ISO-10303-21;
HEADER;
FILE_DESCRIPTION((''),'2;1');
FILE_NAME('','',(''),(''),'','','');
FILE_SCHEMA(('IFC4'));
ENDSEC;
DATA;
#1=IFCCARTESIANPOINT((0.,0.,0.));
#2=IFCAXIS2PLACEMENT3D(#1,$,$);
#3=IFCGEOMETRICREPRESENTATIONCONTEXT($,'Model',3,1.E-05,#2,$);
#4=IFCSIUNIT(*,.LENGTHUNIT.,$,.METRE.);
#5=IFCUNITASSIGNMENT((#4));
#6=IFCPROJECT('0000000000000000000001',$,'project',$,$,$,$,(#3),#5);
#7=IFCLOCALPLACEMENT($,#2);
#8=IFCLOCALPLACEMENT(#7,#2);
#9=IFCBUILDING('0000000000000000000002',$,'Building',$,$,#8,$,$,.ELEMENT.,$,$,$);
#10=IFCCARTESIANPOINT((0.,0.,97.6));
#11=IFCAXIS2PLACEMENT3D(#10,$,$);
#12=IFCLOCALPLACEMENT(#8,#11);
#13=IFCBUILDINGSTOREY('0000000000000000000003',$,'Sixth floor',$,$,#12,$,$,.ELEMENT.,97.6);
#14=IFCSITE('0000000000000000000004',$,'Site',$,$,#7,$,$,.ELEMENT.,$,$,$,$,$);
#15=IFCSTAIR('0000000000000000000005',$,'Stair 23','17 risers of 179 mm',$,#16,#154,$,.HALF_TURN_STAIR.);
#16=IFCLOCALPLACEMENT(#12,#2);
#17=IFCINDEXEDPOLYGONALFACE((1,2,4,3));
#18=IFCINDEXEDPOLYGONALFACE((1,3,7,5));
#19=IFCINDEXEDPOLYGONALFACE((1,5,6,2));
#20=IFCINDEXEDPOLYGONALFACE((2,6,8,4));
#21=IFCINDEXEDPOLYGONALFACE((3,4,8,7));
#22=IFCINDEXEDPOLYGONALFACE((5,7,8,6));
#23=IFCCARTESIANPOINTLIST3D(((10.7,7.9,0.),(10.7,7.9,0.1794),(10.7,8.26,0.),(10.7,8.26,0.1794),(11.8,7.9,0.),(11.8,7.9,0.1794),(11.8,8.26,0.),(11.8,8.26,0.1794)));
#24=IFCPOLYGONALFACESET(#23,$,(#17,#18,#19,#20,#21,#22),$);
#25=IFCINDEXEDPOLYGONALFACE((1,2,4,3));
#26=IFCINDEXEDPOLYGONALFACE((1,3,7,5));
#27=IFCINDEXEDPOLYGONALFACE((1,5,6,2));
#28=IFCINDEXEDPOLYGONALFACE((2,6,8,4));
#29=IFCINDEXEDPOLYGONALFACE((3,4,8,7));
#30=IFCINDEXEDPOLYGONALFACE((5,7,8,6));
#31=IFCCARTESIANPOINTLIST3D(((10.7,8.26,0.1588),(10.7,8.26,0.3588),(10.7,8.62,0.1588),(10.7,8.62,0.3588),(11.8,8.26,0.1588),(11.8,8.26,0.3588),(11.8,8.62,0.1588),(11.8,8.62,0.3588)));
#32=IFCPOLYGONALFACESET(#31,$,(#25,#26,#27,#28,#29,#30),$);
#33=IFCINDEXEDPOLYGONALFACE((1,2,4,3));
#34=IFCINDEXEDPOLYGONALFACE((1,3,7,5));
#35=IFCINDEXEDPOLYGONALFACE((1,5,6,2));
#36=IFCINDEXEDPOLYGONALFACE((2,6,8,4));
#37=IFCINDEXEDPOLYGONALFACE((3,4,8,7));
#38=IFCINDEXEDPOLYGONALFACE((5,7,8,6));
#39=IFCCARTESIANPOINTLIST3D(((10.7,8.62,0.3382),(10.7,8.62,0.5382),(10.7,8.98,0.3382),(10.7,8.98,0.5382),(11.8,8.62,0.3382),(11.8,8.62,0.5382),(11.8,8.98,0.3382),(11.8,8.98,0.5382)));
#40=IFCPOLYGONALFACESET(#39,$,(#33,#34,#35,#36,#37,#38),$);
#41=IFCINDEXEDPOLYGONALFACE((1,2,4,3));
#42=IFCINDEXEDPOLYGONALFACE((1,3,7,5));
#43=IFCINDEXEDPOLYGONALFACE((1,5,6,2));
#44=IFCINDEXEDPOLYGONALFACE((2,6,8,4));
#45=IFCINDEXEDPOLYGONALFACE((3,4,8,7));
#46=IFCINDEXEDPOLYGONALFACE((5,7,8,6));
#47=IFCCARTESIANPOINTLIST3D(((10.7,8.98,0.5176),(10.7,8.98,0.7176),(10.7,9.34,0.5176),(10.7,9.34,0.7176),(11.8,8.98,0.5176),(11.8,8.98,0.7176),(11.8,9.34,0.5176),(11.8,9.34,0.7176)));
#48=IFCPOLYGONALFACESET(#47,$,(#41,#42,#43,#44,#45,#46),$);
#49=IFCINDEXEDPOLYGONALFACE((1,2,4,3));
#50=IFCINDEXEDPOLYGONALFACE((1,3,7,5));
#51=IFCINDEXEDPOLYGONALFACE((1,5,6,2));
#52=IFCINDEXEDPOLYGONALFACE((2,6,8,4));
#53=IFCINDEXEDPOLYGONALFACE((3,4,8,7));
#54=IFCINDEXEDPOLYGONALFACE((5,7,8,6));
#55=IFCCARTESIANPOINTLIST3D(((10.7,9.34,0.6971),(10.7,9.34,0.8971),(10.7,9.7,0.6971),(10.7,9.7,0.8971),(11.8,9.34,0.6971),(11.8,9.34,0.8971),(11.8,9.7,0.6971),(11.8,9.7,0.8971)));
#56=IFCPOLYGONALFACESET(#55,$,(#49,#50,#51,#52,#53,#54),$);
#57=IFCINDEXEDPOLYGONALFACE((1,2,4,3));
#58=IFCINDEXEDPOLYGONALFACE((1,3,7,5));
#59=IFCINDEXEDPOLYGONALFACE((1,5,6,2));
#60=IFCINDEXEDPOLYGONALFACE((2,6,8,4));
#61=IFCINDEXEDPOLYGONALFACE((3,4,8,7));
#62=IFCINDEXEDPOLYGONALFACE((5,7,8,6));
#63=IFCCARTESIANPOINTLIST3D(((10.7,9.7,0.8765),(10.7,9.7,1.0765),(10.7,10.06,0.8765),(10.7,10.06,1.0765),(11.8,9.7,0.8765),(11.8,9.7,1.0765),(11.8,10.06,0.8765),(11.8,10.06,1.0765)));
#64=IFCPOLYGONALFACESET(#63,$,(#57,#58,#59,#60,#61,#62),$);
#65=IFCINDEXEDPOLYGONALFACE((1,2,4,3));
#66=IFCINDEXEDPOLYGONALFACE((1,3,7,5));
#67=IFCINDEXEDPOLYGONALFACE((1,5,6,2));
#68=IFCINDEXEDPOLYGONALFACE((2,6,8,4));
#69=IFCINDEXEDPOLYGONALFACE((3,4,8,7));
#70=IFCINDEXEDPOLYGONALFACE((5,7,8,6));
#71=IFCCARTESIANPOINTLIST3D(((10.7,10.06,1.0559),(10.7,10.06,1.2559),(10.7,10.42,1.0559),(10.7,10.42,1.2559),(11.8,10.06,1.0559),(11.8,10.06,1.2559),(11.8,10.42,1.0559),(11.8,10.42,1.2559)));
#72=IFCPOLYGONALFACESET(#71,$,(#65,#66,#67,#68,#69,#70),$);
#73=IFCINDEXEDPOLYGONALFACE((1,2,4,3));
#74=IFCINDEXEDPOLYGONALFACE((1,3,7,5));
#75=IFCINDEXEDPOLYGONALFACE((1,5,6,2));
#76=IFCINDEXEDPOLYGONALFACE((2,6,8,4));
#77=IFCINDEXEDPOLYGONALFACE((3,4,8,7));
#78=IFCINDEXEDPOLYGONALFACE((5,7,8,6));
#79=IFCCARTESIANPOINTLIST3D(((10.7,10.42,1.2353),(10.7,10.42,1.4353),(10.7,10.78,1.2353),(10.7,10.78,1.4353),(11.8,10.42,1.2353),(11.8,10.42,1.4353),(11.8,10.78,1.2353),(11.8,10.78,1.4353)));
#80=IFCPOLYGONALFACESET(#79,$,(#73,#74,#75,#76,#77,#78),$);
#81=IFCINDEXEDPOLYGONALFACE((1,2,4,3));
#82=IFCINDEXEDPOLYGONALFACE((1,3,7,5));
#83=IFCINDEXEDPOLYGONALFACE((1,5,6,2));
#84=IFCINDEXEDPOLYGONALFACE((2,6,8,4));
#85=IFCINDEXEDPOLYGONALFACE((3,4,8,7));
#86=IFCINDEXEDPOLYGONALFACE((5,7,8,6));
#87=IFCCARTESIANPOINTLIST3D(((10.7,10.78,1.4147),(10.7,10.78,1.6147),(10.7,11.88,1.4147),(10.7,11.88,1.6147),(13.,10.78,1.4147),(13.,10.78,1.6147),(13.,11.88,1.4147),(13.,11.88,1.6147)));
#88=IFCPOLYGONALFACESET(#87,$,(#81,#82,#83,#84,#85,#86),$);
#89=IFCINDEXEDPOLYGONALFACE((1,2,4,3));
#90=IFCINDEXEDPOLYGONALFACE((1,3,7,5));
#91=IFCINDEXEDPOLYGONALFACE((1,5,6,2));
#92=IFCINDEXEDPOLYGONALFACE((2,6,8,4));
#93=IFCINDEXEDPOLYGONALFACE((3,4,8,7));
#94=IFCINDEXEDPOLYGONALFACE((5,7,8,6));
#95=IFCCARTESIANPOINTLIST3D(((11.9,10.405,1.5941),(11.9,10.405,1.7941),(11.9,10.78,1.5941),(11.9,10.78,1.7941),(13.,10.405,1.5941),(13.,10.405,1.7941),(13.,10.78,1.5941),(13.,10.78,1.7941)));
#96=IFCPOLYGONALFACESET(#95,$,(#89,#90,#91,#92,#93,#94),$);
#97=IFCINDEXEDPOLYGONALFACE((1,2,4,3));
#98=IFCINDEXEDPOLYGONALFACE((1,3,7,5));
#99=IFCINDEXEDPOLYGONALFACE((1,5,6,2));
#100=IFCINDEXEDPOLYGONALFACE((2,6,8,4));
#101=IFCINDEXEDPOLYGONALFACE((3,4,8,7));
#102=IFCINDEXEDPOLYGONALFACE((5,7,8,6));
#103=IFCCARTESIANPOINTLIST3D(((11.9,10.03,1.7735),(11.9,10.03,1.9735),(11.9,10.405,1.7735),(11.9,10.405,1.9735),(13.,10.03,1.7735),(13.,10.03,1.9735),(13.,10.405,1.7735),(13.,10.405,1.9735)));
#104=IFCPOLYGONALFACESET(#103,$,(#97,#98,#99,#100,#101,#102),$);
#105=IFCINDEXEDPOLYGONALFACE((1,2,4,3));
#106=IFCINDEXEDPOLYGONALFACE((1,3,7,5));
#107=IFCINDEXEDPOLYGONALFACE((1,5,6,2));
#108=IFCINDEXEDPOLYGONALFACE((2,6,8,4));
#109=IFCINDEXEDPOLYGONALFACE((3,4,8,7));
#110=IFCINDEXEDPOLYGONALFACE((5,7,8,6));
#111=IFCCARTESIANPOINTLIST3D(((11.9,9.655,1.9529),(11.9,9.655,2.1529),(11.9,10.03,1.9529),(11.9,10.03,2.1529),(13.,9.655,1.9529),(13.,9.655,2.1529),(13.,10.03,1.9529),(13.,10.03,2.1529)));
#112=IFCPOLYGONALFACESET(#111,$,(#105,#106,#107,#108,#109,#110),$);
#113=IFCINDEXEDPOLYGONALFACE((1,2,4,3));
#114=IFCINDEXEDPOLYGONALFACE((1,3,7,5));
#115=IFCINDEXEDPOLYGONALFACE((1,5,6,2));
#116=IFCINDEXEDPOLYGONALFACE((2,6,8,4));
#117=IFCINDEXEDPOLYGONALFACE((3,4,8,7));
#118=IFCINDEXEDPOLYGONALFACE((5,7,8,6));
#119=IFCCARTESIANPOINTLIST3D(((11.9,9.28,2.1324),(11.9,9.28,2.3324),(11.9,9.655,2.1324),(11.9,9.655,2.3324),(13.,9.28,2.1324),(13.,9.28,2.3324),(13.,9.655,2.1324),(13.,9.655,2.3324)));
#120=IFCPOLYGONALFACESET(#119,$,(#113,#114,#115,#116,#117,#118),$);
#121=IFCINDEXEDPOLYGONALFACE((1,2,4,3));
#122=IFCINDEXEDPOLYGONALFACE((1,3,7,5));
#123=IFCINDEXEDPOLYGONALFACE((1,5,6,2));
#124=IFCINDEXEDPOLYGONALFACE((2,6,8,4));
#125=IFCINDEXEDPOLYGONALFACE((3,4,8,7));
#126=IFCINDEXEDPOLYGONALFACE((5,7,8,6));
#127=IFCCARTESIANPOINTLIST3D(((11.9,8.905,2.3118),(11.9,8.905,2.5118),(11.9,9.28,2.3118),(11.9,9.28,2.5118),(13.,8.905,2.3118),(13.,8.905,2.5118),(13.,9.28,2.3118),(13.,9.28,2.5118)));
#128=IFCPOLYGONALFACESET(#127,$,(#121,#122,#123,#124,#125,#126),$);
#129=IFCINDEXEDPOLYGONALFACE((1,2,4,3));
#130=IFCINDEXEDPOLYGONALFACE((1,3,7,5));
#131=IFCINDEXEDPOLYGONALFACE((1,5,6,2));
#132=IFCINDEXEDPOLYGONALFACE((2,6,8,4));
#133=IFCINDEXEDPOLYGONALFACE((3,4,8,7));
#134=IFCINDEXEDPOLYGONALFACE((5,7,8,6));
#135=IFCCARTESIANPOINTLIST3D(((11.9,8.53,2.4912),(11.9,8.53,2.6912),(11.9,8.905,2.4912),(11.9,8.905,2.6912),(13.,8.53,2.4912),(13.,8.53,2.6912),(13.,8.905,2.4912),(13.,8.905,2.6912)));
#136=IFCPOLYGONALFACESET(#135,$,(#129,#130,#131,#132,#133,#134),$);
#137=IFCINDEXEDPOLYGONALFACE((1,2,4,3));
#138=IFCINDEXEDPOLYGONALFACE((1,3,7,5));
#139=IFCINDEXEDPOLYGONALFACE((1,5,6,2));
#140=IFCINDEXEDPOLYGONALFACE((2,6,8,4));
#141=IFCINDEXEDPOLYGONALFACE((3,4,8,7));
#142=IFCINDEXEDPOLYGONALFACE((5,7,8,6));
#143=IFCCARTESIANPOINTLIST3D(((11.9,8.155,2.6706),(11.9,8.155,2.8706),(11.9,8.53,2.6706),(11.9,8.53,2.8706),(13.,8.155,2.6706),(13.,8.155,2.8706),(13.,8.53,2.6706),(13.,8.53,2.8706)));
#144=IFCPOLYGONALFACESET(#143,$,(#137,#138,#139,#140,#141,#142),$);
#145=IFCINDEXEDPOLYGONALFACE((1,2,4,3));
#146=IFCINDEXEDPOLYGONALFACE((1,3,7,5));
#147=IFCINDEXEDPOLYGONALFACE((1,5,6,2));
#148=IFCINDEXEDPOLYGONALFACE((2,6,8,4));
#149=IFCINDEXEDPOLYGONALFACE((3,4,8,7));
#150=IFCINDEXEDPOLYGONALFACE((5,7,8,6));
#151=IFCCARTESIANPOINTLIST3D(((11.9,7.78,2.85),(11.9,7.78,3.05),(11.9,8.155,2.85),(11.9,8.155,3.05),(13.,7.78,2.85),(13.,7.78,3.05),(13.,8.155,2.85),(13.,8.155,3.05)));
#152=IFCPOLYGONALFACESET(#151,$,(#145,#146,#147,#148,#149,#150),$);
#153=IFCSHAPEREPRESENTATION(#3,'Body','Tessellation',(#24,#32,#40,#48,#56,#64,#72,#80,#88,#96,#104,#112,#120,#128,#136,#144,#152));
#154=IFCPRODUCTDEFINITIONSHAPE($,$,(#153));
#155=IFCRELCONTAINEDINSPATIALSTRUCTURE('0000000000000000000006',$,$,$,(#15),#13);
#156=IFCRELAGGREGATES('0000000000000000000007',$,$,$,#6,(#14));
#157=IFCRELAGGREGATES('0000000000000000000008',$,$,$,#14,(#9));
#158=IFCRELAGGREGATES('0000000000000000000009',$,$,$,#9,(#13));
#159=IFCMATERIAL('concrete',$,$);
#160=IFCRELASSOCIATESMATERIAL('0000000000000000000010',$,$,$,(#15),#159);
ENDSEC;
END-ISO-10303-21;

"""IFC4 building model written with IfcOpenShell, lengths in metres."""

from ifc_helpers import new_model, si_unit, frame, origin, place, context, project, spatial, polyline, outline, extrude, material, element, save


model = new_model("IFC4")

# Units and contexts
model_context = context("Model", 3, precision=1e-05, world=origin())
ifc_project = project(units=[si_unit("LENGTHUNIT", "METRE")], contexts=[model_context])

# Site, building, storey
site_placement = place(None, origin())
site = spatial("IfcSite", under=ifc_project, at=site_placement, Name="Site", CompositionType="ELEMENT")
building_placement = place(site_placement, origin())
building = spatial("IfcBuilding", under=site, at=building_placement, Name="Building", CompositionType="ELEMENT")
storey_placement = place(building_placement, frame((0.0, 0.0, 97.6)))
storey = spatial("IfcBuildingStorey", under=building, at=storey_placement, Name="Sixth floor", CompositionType="ELEMENT", Elevation=97.6)

# Shared definitions
ifc_material = material(Name="concrete")

# Stair
stair_placement = place(storey_placement, frame((11.25, 7.9, 0.0), z_axis=(0.0, 0.0, 1.0), x_axis=(0.0, 1.0, 0.0)))
element("IfcStair", 1, at=stair_placement, inside=storey, material=ifc_material, Name="Stair 23", Description="17 risers of 179 mm", PredefinedType="HALF_TURN_STAIR", context=model_context, shape_type="SweptSolid", body=[
    extrude(outline(polyline([(0.0, -0.55), (0.36, -0.55), (0.36, 0.55), (0.0, 0.55), (0.0, -0.55)])), origin(), (0.0, 0.0, 1.0), 0.1794),
    extrude(outline(polyline([(0.36, -0.55), (0.72, -0.55), (0.72, 0.55), (0.36, 0.55), (0.36, -0.55)])), frame((0.0, 0.0, 0.1588)), (0.0, 0.0, 1.0), 0.2),
    extrude(outline(polyline([(0.72, -0.55), (1.08, -0.55), (1.08, 0.55), (0.72, 0.55), (0.72, -0.55)])), frame((0.0, 0.0, 0.3382)), (0.0, 0.0, 1.0), 0.2),
    extrude(outline(polyline([(1.08, -0.55), (1.44, -0.55), (1.44, 0.55), (1.08, 0.55), (1.08, -0.55)])), frame((0.0, 0.0, 0.5176)), (0.0, 0.0, 1.0), 0.2),
    extrude(outline(polyline([(1.44, -0.55), (1.8, -0.55), (1.8, 0.55), (1.44, 0.55), (1.44, -0.55)])), frame((0.0, 0.0, 0.6971)), (0.0, 0.0, 1.0), 0.2),
    extrude(outline(polyline([(1.8, -0.55), (2.16, -0.55), (2.16, 0.55), (1.8, 0.55), (1.8, -0.55)])), frame((0.0, 0.0, 0.8765)), (0.0, 0.0, 1.0), 0.2),
    extrude(outline(polyline([(2.16, -0.55), (2.52, -0.55), (2.52, 0.55), (2.16, 0.55), (2.16, -0.55)])), frame((0.0, 0.0, 1.0559)), (0.0, 0.0, 1.0), 0.2),
    extrude(outline(polyline([(2.52, -0.55), (2.88, -0.55), (2.88, 0.55), (2.52, 0.55), (2.52, -0.55)])), frame((0.0, 0.0, 1.2353)), (0.0, 0.0, 1.0), 0.2),
    extrude(outline(polyline([(2.88, -1.75), (3.98, -1.75), (3.98, 0.55), (2.88, 0.55), (2.88, -1.75)])), frame((0.0, 0.0, 1.4147)), (0.0, 0.0, 1.0), 0.2),
    extrude(outline(polyline([(2.505, -1.75), (2.88, -1.75), (2.88, -0.65), (2.505, -0.65), (2.505, -1.75)])), frame((0.0, 0.0, 1.5941)), (0.0, 0.0, 1.0), 0.2),
    extrude(outline(polyline([(2.13, -1.75), (2.505, -1.75), (2.505, -0.65), (2.13, -0.65), (2.13, -1.75)])), frame((0.0, 0.0, 1.7735)), (0.0, 0.0, 1.0), 0.2),
    extrude(outline(polyline([(1.755, -1.75), (2.13, -1.75), (2.13, -0.65), (1.755, -0.65), (1.755, -1.75)])), frame((0.0, 0.0, 1.9529)), (0.0, 0.0, 1.0), 0.2),
    extrude(outline(polyline([(1.38, -1.75), (1.755, -1.75), (1.755, -0.65), (1.38, -0.65), (1.38, -1.75)])), frame((0.0, 0.0, 2.1324)), (0.0, 0.0, 1.0), 0.2),
    extrude(outline(polyline([(1.005, -1.75), (1.38, -1.75), (1.38, -0.65), (1.005, -0.65), (1.005, -1.75)])), frame((0.0, 0.0, 2.3118)), (0.0, 0.0, 1.0), 0.2),
    extrude(outline(polyline([(0.63, -1.75), (1.005, -1.75), (1.005, -0.65), (0.63, -0.65), (0.63, -1.75)])), frame((0.0, 0.0, 2.4912)), (0.0, 0.0, 1.0), 0.2),
    extrude(outline(polyline([(0.255, -1.75), (0.63, -1.75), (0.63, -0.65), (0.255, -0.65), (0.255, -1.75)])), frame((0.0, 0.0, 2.6706)), (0.0, 0.0, 1.0), 0.2),
    extrude(outline(polyline([(-0.12, -1.75), (0.255, -1.75), (0.255, -0.65), (-0.12, -0.65), (-0.12, -1.75)])), frame((0.0, 0.0, 2.85)), (0.0, 0.0, 1.0), 0.2),
])

save(model, "model.ifc")
